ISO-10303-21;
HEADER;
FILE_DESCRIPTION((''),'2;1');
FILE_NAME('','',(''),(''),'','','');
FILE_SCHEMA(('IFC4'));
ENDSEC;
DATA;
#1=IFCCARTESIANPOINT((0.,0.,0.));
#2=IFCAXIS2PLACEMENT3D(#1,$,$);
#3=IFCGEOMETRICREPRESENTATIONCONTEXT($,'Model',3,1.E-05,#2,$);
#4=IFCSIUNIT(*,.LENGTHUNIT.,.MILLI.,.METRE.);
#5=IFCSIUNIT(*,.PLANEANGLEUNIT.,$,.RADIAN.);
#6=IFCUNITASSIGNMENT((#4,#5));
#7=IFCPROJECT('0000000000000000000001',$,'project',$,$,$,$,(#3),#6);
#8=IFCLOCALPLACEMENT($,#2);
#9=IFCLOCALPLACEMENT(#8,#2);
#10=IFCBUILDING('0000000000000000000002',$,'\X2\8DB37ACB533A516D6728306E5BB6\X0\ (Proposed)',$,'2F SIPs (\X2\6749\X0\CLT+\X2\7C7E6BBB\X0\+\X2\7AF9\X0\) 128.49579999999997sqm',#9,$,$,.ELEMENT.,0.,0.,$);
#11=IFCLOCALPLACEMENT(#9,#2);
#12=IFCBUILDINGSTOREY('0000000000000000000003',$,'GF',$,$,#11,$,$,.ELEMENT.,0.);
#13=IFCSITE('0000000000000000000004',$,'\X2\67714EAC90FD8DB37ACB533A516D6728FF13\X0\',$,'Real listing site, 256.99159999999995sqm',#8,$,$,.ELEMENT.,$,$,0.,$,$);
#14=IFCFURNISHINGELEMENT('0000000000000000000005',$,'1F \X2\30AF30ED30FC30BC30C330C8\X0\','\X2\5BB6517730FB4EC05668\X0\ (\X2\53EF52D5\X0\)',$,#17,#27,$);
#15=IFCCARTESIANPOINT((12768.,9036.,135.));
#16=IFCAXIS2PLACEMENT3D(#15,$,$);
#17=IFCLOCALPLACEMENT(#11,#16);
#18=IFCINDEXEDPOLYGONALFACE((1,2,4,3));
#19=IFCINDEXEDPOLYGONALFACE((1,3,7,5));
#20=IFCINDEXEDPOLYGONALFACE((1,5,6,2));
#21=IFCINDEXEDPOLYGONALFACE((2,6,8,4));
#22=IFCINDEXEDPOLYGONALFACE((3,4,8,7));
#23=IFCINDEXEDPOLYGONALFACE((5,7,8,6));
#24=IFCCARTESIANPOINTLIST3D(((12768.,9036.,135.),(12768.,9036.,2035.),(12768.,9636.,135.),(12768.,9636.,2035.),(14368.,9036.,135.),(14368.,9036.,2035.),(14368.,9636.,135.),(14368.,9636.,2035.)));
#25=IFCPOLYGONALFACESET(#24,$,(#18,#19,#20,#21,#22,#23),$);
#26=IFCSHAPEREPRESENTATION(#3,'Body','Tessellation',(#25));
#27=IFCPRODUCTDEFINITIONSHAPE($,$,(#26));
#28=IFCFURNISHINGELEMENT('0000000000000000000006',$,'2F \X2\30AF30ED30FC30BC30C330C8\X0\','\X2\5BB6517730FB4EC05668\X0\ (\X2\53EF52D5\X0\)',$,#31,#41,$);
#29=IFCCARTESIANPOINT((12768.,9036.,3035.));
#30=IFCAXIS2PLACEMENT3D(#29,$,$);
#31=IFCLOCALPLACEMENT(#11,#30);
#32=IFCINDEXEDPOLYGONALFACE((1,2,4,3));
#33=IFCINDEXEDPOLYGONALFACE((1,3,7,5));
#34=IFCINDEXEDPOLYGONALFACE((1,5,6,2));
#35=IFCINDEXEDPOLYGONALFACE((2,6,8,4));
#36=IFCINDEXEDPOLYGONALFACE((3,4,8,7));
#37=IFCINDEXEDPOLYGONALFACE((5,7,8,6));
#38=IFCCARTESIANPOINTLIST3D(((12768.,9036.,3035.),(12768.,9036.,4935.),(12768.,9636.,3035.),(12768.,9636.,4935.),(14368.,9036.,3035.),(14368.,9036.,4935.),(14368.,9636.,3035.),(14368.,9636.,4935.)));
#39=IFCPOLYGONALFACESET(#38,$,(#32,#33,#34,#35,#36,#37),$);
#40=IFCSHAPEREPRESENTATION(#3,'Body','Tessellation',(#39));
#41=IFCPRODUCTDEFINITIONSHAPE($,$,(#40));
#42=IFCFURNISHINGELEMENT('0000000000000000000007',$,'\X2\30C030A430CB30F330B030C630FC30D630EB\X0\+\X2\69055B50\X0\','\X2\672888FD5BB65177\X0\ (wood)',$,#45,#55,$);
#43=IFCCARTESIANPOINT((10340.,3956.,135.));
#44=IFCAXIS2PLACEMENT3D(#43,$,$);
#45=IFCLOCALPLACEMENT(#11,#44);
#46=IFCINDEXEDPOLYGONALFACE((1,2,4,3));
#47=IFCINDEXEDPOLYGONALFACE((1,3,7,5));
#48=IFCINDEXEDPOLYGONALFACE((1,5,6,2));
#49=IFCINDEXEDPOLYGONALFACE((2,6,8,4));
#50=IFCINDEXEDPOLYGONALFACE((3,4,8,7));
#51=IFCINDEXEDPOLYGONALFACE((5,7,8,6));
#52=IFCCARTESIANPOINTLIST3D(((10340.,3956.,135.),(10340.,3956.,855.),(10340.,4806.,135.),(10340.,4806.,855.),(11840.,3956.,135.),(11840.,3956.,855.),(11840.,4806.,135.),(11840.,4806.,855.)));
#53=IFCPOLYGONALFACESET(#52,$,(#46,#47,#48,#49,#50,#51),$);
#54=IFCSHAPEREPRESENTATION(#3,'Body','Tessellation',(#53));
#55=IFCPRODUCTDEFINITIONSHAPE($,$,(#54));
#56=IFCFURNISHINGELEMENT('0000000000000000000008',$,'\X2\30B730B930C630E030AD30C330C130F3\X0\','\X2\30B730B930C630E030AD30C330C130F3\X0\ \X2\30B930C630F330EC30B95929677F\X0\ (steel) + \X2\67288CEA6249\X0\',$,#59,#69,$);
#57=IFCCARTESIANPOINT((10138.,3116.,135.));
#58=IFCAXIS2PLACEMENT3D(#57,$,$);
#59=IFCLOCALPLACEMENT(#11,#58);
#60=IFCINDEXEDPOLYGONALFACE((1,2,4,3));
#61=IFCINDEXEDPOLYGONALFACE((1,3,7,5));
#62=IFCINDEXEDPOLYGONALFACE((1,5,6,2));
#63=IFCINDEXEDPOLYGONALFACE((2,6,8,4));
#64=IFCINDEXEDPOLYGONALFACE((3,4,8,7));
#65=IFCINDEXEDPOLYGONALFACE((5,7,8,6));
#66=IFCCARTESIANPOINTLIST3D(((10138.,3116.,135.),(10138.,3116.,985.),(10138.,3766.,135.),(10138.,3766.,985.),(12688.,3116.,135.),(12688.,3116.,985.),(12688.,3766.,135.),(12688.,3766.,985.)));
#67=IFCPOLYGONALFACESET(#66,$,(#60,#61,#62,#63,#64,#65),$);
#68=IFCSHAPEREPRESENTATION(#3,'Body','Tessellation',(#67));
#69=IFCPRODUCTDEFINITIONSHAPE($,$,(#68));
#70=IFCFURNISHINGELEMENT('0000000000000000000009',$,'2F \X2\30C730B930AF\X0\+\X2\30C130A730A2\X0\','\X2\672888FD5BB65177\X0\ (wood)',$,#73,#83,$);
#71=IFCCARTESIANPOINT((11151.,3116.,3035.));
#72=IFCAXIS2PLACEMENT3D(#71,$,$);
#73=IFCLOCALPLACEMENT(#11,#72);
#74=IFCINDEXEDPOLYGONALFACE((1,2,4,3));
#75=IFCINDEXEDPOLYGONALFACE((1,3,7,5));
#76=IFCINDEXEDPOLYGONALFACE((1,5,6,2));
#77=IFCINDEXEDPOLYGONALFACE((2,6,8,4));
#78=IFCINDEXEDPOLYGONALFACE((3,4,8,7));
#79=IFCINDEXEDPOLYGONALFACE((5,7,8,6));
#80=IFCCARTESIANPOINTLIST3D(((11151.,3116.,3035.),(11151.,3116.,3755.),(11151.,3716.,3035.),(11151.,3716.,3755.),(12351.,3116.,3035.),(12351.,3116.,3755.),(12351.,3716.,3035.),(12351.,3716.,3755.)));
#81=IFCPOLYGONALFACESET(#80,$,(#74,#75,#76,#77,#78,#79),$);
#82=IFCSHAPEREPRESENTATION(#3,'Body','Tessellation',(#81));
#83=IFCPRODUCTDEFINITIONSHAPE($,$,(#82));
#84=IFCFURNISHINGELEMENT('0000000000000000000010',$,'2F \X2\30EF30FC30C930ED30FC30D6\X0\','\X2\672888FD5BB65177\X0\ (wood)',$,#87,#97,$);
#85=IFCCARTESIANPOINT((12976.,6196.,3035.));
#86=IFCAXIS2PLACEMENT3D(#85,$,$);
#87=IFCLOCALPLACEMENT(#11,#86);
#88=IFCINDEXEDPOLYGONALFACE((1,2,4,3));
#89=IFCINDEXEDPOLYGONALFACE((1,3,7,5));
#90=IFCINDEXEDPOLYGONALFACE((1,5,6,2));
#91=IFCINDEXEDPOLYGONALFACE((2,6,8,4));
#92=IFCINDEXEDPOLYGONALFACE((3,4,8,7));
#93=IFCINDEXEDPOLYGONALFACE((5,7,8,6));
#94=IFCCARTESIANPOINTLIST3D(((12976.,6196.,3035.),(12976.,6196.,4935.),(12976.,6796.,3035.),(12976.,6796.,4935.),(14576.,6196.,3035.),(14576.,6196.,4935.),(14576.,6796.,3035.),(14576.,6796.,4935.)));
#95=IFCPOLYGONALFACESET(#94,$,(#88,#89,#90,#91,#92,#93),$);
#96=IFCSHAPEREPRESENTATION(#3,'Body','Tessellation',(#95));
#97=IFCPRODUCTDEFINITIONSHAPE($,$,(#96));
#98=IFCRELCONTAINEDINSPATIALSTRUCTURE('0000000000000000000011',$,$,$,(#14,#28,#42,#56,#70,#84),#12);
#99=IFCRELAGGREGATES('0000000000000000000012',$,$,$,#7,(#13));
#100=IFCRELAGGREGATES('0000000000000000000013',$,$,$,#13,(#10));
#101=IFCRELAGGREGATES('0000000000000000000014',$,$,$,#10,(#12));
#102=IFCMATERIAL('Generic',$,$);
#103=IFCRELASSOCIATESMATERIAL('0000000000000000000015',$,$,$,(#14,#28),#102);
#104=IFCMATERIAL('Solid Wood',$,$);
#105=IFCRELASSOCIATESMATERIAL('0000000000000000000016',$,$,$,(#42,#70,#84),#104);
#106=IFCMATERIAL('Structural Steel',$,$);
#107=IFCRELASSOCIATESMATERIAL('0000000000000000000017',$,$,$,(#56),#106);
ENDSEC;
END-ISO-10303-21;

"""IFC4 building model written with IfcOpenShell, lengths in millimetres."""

from ifc_helpers import new_model, si_unit, frame, frame_2d, origin, place, context, project, spatial, rectangle, extrude, material, element, save


model = new_model("IFC4")

# Units and contexts
model_context = context("Model", 3, precision=1e-05, world=origin())
ifc_project = project(units=[si_unit("LENGTHUNIT", "METRE", prefix="MILLI"), si_unit("PLANEANGLEUNIT", "RADIAN")], contexts=[model_context])

# Site, building, storey
site_placement = place(None, origin())
site = spatial("IfcSite", under=ifc_project, at=site_placement, Name="東京都足立区六木３", ObjectType="Real listing site, 256.99159999999995sqm", CompositionType="ELEMENT", RefElevation=0.0)
building_placement = place(site_placement, origin())
building = spatial("IfcBuilding", under=site, at=building_placement, Name="足立区六木の家 (Proposed)", ObjectType="2F SIPs (杉CLT+籾殻+竹) 128.49579999999997sqm", CompositionType="ELEMENT", ElevationOfRefHeight=0.0, ElevationOfTerrain=0.0)
storey_placement = place(building_placement, origin())
storey = spatial("IfcBuildingStorey", under=building, at=storey_placement, Name="GF", CompositionType="ELEMENT", Elevation=0.0)

# Shared definitions
ifc_material_1 = material(Name="Solid Wood")

# Shared definitions
ifc_material_2 = material(Name="Generic")

# Furnishing elements
furnishing_1_placement = place(storey_placement, frame((12768.0, 9036.0, 135.0)))
element("IfcFurnishingElement", 1, at=furnishing_1_placement, inside=storey, material=ifc_material_2, Name="1F クローゼット", Description="家具・什器 (可動)", context=model_context, shape_type="SweptSolid", body=[
    extrude(rectangle(XDim=1600.0, YDim=600.0, at=frame_2d((800.0, 300.0))), frame((12768.0, 9036.0, 135.0)), (0.0, 0.0, 1.0), 1900.0),
])
furnishing_2_placement = place(storey_placement, frame((12768.0, 9036.0, 3035.0)))
element("IfcFurnishingElement", 2, at=furnishing_2_placement, inside=storey, material=ifc_material_2, Name="2F クローゼット", Description="家具・什器 (可動)", context=model_context, shape_type="SweptSolid", body=[
    extrude(rectangle(XDim=1600.0, YDim=600.0, at=frame_2d((800.0, 300.0))), frame((12768.0, 9036.0, 3035.0)), (0.0, 0.0, 1.0), 1900.0),
])
furnishing_3_placement = place(storey_placement, frame((10340.0, 3956.0, 135.0)))
element("IfcFurnishingElement", 3, at=furnishing_3_placement, inside=storey, material=ifc_material_1, Name="ダイニングテーブル+椅子", Description="木製家具 (wood)", context=model_context, shape_type="SweptSolid", body=[
    extrude(rectangle(XDim=1500.0, YDim=850.0, at=frame_2d((750.0, 425.0))), frame((10340.0, 3956.0, 135.0)), (0.0, 0.0, 1.0), 720.0),
])
ifc_material_3 = material(Name="Structural Steel")
furnishing_4_placement = place(storey_placement, frame((10138.0, 3116.0, 135.0)))
element("IfcFurnishingElement", 4, at=furnishing_4_placement, inside=storey, material=ifc_material_3, Name="システムキッチン", Description="システムキッチン ステンレス天板 (steel) + 木質扉", context=model_context, shape_type="SweptSolid", body=[
    extrude(rectangle(XDim=2550.0, YDim=650.0, at=frame_2d((1275.0, 325.0))), frame((10138.0, 3116.0, 135.0)), (0.0, 0.0, 1.0), 850.0),
])
furnishing_5_placement = place(storey_placement, frame((11151.0, 3116.0, 3035.0)))
element("IfcFurnishingElement", 5, at=furnishing_5_placement, inside=storey, material=ifc_material_1, Name="2F デスク+チェア", Description="木製家具 (wood)", context=model_context, shape_type="SweptSolid", body=[
    extrude(rectangle(XDim=1200.0, YDim=600.0, at=frame_2d((600.0, 300.0))), frame((11151.0, 3116.0, 3035.0)), (0.0, 0.0, 1.0), 720.0),
])
furnishing_6_placement = place(storey_placement, frame((12976.0, 6196.0, 3035.0)))
element("IfcFurnishingElement", 6, at=furnishing_6_placement, inside=storey, material=ifc_material_1, Name="2F ワードローブ", Description="木製家具 (wood)", context=model_context, shape_type="SweptSolid", body=[
    extrude(rectangle(XDim=1600.0, YDim=600.0, at=frame_2d((800.0, 300.0))), frame((12976.0, 6196.0, 3035.0)), (0.0, 0.0, 1.0), 1900.0),
])

save(model, "model.ifc")
